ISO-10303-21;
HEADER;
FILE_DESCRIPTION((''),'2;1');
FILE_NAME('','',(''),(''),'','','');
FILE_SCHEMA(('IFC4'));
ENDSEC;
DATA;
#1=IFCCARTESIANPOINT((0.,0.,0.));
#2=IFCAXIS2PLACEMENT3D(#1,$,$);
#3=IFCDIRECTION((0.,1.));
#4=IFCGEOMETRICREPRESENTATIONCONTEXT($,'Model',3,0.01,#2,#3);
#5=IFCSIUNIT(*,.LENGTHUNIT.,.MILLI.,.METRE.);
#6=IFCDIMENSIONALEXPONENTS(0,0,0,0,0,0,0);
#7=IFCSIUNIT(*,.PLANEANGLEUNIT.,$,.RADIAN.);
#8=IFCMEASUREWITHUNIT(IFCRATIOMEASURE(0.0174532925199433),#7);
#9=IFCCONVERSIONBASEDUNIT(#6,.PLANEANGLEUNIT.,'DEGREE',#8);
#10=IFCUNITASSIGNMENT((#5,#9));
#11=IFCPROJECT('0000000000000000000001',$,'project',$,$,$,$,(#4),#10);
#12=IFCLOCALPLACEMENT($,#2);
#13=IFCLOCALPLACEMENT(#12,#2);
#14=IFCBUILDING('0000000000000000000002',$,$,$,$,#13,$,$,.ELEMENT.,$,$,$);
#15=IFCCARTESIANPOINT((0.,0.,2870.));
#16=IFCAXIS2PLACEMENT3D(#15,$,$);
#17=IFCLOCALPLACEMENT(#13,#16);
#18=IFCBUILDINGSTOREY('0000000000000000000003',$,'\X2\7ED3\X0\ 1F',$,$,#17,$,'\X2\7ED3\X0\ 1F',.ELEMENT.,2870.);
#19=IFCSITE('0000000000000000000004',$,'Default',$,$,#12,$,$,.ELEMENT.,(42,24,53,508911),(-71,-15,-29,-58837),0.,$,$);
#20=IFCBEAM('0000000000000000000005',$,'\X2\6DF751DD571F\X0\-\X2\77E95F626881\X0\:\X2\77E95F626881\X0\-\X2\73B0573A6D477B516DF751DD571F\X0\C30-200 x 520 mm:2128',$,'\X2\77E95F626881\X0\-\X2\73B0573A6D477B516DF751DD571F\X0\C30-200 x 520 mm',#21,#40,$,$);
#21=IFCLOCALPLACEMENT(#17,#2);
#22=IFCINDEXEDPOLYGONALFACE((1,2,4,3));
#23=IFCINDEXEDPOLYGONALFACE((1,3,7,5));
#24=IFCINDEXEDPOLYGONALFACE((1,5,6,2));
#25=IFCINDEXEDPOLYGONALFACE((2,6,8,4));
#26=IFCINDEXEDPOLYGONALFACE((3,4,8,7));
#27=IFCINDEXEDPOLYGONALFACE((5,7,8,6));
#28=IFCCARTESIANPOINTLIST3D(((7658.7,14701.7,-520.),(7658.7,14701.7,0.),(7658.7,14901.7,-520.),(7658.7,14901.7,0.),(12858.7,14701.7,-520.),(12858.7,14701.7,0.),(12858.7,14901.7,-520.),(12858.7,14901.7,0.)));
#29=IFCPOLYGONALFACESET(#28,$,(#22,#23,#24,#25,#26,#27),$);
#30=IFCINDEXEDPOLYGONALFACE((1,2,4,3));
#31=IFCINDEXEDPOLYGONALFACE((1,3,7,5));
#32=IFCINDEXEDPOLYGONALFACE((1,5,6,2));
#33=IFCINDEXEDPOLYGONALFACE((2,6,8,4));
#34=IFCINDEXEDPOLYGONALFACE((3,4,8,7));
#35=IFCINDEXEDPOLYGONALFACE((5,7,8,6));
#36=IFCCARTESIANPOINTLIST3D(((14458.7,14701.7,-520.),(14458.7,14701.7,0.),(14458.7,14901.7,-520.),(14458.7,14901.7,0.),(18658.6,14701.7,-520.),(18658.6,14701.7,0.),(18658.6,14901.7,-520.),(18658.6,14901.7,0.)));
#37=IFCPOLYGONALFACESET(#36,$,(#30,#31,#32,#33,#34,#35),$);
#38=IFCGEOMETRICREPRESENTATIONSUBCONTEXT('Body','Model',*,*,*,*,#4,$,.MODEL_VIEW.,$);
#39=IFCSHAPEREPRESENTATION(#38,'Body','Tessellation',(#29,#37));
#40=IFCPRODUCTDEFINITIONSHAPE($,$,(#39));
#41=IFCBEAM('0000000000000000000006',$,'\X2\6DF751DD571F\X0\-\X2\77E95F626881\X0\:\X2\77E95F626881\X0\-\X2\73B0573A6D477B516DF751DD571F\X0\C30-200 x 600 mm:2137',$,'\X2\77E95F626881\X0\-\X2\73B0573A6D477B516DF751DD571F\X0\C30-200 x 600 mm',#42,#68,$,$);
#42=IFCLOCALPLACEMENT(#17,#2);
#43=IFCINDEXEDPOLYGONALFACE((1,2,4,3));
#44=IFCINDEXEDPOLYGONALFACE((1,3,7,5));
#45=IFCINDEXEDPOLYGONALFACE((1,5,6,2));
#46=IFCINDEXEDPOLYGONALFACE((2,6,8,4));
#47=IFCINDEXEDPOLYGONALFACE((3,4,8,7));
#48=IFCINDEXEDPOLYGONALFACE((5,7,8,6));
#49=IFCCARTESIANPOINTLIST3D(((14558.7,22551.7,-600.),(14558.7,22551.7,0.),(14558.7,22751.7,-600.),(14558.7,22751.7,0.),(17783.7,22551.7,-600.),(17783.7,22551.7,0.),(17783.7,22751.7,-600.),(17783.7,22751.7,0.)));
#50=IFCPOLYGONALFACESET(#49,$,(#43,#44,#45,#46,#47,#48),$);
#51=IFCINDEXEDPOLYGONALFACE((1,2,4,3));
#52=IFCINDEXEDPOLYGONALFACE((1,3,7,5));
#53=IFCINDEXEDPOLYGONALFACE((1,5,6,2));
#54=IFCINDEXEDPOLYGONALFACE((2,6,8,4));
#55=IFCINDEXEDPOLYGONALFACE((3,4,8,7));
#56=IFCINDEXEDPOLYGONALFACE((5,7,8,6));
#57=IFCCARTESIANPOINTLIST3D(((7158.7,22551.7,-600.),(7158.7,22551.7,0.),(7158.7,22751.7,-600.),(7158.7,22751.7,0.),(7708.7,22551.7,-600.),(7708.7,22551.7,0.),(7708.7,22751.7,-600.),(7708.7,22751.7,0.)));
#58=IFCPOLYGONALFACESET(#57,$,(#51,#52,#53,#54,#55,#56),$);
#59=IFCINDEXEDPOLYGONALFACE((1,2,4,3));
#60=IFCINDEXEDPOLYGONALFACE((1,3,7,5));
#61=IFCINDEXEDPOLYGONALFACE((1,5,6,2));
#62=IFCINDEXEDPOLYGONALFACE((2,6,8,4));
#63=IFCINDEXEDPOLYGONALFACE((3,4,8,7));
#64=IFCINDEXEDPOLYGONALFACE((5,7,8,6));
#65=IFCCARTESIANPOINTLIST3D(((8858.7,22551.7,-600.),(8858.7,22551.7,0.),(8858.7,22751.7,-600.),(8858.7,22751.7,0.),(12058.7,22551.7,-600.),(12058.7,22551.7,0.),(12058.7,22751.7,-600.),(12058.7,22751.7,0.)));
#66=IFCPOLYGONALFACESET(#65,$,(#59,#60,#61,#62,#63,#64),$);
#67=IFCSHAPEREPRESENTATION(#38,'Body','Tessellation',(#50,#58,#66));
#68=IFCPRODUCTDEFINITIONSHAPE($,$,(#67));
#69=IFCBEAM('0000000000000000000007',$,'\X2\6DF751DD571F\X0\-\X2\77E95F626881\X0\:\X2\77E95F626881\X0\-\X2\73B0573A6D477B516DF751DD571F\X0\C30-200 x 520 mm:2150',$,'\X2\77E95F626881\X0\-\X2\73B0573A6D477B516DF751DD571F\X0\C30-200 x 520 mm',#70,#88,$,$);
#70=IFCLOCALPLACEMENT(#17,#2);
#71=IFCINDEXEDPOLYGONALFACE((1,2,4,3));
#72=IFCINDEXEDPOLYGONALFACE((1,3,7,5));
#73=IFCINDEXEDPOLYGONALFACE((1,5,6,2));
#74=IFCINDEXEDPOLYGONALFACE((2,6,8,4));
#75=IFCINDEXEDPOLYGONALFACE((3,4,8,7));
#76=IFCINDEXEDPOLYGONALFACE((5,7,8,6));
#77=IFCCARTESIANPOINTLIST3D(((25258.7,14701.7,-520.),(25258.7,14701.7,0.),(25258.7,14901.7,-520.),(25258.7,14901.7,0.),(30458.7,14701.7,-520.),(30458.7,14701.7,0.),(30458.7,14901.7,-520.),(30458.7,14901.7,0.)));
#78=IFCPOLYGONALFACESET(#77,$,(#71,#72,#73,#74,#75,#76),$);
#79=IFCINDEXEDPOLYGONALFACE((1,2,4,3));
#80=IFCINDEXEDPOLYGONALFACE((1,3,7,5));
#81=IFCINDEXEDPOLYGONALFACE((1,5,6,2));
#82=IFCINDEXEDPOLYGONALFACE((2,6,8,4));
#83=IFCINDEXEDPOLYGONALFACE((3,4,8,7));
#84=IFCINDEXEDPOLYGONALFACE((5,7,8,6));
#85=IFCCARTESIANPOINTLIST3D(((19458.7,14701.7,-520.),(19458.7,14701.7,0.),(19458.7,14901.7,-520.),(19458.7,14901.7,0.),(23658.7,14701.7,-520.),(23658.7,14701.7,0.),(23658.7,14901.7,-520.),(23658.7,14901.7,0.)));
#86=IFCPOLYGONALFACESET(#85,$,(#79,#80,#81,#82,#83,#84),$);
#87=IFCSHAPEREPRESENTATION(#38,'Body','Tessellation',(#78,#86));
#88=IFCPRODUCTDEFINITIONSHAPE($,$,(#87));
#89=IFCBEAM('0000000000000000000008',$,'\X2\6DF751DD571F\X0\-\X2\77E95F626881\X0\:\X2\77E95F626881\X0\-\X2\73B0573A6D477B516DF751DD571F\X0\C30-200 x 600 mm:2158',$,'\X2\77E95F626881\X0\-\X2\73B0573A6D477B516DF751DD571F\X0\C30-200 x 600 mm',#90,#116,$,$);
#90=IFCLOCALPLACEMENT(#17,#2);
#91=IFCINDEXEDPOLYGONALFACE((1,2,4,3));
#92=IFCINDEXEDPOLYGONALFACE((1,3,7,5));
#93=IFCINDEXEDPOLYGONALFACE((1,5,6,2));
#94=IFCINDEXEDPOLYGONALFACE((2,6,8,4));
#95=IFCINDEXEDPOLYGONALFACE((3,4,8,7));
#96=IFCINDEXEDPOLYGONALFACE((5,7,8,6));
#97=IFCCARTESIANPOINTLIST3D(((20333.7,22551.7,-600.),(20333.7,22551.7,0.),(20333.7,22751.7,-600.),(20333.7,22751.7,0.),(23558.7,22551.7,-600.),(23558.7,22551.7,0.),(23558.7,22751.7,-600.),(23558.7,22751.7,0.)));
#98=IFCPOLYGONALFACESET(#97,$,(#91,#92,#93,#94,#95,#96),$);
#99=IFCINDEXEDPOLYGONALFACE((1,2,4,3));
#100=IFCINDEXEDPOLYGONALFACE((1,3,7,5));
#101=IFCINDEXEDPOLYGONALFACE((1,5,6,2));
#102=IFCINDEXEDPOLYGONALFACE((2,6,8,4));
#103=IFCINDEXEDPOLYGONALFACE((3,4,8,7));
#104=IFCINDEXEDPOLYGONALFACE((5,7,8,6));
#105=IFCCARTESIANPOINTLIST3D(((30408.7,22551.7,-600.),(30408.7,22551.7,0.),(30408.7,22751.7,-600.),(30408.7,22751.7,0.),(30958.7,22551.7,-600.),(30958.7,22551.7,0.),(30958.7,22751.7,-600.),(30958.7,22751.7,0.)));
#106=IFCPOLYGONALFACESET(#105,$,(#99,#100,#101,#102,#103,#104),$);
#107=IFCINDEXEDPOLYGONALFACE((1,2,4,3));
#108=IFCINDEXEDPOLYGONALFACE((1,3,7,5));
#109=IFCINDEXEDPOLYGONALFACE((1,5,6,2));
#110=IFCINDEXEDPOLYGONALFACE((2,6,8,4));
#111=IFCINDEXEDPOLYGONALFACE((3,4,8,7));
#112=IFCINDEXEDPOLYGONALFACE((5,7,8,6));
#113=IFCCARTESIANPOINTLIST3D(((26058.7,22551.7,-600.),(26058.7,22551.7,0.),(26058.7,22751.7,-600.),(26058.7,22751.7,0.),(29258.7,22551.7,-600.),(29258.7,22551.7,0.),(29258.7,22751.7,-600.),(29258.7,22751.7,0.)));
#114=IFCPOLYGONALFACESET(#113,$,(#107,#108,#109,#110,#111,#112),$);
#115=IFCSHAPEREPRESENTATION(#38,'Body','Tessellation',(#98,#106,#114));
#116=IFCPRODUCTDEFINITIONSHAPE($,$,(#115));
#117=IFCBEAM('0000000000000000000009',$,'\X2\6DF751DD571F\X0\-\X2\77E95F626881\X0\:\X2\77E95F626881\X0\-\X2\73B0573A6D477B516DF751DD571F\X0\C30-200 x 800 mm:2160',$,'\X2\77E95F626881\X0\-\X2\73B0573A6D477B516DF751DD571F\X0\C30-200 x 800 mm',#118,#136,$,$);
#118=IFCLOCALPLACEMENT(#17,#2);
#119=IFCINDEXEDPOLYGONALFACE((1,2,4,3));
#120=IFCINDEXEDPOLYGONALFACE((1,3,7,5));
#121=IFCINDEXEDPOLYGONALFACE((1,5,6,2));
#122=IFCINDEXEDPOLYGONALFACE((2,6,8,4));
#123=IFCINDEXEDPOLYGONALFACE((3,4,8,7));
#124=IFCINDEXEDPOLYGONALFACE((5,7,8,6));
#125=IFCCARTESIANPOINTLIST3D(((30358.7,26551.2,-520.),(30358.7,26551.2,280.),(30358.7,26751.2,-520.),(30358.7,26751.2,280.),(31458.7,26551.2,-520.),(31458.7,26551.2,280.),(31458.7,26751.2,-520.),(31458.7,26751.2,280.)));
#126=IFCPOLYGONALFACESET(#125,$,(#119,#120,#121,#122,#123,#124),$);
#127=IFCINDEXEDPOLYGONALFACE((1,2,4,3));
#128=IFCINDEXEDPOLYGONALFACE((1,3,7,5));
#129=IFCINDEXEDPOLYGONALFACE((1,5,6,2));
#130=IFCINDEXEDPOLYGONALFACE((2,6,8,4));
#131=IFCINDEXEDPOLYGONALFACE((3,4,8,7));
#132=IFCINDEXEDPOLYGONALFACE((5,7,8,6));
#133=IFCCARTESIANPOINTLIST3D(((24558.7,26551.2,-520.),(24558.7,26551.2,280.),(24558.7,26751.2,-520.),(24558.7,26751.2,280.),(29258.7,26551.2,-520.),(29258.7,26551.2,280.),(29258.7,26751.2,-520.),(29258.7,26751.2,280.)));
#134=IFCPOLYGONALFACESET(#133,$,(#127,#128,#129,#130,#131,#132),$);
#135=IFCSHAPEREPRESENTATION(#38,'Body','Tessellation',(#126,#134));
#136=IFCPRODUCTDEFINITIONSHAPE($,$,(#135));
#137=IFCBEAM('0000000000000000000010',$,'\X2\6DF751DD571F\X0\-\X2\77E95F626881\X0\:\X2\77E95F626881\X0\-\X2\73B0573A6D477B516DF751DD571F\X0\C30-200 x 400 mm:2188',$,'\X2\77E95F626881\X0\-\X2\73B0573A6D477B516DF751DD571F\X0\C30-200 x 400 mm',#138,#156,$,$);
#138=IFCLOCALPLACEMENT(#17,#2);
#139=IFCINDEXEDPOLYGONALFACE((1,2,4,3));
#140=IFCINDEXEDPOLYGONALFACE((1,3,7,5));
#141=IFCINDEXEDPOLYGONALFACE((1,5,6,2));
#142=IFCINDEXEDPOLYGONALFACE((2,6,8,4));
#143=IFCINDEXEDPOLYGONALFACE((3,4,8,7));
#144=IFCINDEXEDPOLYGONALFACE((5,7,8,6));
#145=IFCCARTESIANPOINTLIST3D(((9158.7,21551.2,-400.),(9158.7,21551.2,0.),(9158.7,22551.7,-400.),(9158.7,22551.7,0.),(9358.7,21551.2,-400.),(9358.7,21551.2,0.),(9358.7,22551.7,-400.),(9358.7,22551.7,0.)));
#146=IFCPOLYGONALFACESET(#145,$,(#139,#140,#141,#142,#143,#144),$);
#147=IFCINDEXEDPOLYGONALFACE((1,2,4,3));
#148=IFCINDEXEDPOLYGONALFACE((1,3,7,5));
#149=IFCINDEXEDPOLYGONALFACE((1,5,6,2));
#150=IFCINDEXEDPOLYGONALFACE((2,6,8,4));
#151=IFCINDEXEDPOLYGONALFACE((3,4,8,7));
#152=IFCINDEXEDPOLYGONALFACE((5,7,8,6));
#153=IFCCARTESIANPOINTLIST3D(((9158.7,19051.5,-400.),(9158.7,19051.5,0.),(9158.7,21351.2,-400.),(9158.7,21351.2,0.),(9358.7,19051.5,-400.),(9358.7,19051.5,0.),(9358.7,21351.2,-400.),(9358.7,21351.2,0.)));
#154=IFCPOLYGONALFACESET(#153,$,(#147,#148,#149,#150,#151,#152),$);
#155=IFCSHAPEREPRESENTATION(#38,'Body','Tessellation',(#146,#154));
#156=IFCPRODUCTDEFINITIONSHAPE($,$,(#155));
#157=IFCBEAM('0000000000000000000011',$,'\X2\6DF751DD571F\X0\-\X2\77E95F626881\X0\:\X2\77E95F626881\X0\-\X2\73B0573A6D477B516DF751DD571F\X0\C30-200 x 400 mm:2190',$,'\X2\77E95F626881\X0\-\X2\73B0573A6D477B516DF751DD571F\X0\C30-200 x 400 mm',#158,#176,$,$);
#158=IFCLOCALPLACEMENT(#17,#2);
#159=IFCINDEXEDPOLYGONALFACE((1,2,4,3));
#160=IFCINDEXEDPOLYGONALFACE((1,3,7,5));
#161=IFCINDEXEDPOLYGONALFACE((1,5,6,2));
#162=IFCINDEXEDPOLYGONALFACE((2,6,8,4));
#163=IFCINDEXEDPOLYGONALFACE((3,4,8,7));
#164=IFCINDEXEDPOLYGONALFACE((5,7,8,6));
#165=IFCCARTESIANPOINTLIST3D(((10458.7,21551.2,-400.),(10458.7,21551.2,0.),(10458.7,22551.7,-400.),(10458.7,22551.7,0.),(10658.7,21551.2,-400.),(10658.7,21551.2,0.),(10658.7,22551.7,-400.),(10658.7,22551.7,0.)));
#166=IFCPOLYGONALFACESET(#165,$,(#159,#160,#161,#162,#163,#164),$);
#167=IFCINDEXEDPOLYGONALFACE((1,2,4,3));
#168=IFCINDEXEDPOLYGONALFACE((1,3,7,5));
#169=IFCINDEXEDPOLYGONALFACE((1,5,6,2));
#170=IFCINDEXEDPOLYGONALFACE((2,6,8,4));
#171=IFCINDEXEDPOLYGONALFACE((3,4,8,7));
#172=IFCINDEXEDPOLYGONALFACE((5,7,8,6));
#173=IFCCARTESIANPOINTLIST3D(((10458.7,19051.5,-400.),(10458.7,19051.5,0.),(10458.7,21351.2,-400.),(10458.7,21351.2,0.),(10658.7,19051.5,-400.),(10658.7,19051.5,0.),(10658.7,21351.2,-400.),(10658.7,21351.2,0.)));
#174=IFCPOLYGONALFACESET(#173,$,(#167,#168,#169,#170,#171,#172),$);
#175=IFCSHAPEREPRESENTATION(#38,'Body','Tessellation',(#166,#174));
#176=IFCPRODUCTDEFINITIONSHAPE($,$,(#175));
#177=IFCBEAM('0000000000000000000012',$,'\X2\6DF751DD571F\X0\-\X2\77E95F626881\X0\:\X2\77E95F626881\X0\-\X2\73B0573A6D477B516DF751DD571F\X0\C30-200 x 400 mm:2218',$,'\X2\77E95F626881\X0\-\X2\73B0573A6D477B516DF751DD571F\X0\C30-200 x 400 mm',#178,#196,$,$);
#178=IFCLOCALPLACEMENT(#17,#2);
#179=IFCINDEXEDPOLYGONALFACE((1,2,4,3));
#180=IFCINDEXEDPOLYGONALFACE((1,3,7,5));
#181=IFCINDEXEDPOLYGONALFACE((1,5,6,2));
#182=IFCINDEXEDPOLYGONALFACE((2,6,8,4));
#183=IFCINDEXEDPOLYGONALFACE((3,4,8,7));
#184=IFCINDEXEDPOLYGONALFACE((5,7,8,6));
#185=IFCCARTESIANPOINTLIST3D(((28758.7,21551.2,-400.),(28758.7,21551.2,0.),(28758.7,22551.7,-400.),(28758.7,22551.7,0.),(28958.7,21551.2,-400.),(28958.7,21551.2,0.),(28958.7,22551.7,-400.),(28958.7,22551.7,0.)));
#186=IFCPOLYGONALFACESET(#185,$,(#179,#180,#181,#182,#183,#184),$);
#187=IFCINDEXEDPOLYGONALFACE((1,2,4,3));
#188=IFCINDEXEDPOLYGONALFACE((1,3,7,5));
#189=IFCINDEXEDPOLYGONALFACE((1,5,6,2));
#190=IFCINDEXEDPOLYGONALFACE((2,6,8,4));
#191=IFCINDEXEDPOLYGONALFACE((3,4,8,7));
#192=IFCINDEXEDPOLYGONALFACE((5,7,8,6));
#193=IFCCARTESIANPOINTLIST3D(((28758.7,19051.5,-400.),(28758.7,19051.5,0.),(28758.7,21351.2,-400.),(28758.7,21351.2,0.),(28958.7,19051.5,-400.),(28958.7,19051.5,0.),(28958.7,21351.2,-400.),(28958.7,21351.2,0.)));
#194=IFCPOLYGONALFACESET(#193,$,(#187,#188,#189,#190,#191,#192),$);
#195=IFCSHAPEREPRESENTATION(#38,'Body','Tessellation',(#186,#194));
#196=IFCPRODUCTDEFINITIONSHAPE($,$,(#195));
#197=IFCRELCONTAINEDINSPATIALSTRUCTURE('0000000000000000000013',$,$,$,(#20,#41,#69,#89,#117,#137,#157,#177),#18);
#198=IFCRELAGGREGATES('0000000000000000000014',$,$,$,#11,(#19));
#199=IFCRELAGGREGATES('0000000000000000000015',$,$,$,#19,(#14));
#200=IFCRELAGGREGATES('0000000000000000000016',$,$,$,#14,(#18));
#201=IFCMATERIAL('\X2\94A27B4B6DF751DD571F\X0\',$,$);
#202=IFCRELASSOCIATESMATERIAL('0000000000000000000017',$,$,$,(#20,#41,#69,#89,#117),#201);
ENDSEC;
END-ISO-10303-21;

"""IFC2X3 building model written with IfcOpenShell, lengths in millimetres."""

from ifc_helpers import new_model, entity, si_unit, converted_unit, direction, frame, frame_2d, origin, origin_2d_with_axis, place, context, subcontext, project, spatial, rectangle, extrude, source, transform, mapped, material, element, save


model = new_model("IFC2X3")

# Units and contexts
model_context = context("Model", 3, precision=0.01, world=origin(), true_north=direction((0.0, 1.0)))
body_context = subcontext(model_context, "Body", "Model", "MODEL_VIEW")
ifc_project = project(units=[si_unit("LENGTHUNIT", "METRE", prefix="MILLI"), converted_unit("PLANEANGLEUNIT", "DEGREE", entity("IfcRatioMeasure", 0.0174532925199433), si_unit("PLANEANGLEUNIT", "RADIAN"), dimensions=[0, 0, 0, 0, 0, 0, 0])], contexts=[model_context])

# Site, building, storey
site_placement = place(None, origin())
site = spatial("IfcSite", under=ifc_project, at=site_placement, Name="Default", CompositionType="ELEMENT", RefLatitude=(42, 24, 53, 508911), RefLongitude=(-71, -15, -29, -58837), RefElevation=0.0)
building_placement = place(site_placement, origin())
building = spatial("IfcBuilding", under=site, at=building_placement, CompositionType="ELEMENT")
storey_placement = place(building_placement, frame((0.0, 0.0, 2870.0)))
storey = spatial("IfcBuildingStorey", under=building, at=storey_placement, Name="结 1F", LongName="结 1F", CompositionType="ELEMENT", Elevation=2870.0)

# Beams
ifc_material = material(Name="钢筋混凝土")
shared_shape_1 = source(origin(), body_context, "Body", "SweptSolid", [
    extrude(rectangle(XDim=5200.0, YDim=200.0, at=frame_2d((0.0, 0.0), x_axis=(1.0, 0.0))), frame((10258.7, 14801.7, 2350.0)), (0.0, 0.0, 1.0), 520.0),
    extrude(rectangle(XDim=4199.9, YDim=200.0, at=frame_2d((0.0, 0.0), x_axis=(1.0, 0.0))), frame((16558.7, 14801.7, 2350.0), z_axis=(0.0, 0.0, 1.0), x_axis=(-1.0, 0.0, 0.0)), (0.0, 0.0, 1.0), 520.0),
])
beam_1_placement = place(storey_placement, frame((0.0, 0.0, -2870.0)))
element("IfcBeam", 1, at=beam_1_placement, inside=storey, material=ifc_material, Name="混凝土-矩形梁:矩形梁-现场浇筑混凝土C30-200 x 520 mm:2128", ObjectType="矩形梁-现场浇筑混凝土C30-200 x 520 mm", context=body_context, shape_type="MappedRepresentation", body=[
    mapped(shared_shape_1, transform((0.0, 0.0, 0.0), scale=1.0)),
])
shared_shape_2 = source(origin(), body_context, "Body", "SweptSolid", [
    extrude(rectangle(XDim=3225.0, YDim=200.0, at=frame_2d((0.0, 0.0), x_axis=(1.0, 0.0))), frame((16171.2, 22651.7, 2270.0)), (0.0, 0.0, 1.0), 600.0),
    extrude(rectangle(XDim=550.0, YDim=200.0, at=frame_2d((0.0, 0.0), x_axis=(1.0, 0.0))), frame((7433.7, 22651.7, 2270.0), z_axis=(0.0, 0.0, 1.0), x_axis=(-1.0, 0.0, 0.0)), (0.0, 0.0, 1.0), 600.0),
    extrude(rectangle(XDim=3200.0, YDim=200.0, at=frame_2d((0.0, 0.0), x_axis=(1.0, 0.0))), frame((10458.7, 22651.7, 2270.0)), (0.0, 0.0, 1.0), 600.0),
])
beam_2_placement = place(storey_placement, frame((0.0, 0.0, -2870.0)))
element("IfcBeam", 2, at=beam_2_placement, inside=storey, material=ifc_material, Name="混凝土-矩形梁:矩形梁-现场浇筑混凝土C30-200 x 600 mm:2137", ObjectType="矩形梁-现场浇筑混凝土C30-200 x 600 mm", context=body_context, shape_type="MappedRepresentation", body=[
    mapped(shared_shape_2, transform((0.0, 0.0, 0.0), scale=1.0)),
])
shared_shape_3 = source(origin(), body_context, "Body", "SweptSolid", [
    extrude(rectangle(XDim=5200.0, YDim=200.0, at=frame_2d((0.0, 0.0), x_axis=(1.0, 0.0))), frame((27858.7, 14801.7, 2350.0)), (0.0, 0.0, 1.0), 520.0),
    extrude(rectangle(XDim=4200.0, YDim=200.0, at=frame_2d((0.0, 0.0), x_axis=(1.0, 0.0))), frame((21558.7, 14801.7, 2350.0)), (0.0, 0.0, 1.0), 520.0),
])
beam_3_placement = place(storey_placement, frame((0.0, 0.0, -2870.0)))
element("IfcBeam", 3, at=beam_3_placement, inside=storey, material=ifc_material, Name="混凝土-矩形梁:矩形梁-现场浇筑混凝土C30-200 x 520 mm:2150", ObjectType="矩形梁-现场浇筑混凝土C30-200 x 520 mm", context=body_context, shape_type="MappedRepresentation", body=[
    mapped(shared_shape_3, transform((0.0, 0.0, 0.0), scale=1.0)),
])
shared_shape_4 = source(origin(), body_context, "Body", "SweptSolid", [
    extrude(rectangle(XDim=3225.0, YDim=200.0, at=frame_2d((0.0, 0.0), x_axis=(1.0, 0.0))), frame((21946.2, 22651.7, 2270.0)), (0.0, 0.0, 1.0), 600.0),
    extrude(rectangle(XDim=550.0, YDim=200.0, at=frame_2d((0.0, 0.0), x_axis=(1.0, 0.0))), frame((30683.7, 22651.7, 2270.0)), (0.0, 0.0, 1.0), 600.0),
    extrude(rectangle(XDim=3200.0, YDim=200.0, at=frame_2d((0.0, 0.0), x_axis=(1.0, 0.0))), frame((27658.7, 22651.7, 2270.0), z_axis=(0.0, 0.0, 1.0), x_axis=(-1.0, 0.0, 0.0)), (0.0, 0.0, 1.0), 600.0),
])
beam_4_placement = place(storey_placement, frame((0.0, 0.0, -2870.0)))
element("IfcBeam", 4, at=beam_4_placement, inside=storey, material=ifc_material, Name="混凝土-矩形梁:矩形梁-现场浇筑混凝土C30-200 x 600 mm:2158", ObjectType="矩形梁-现场浇筑混凝土C30-200 x 600 mm", context=body_context, shape_type="MappedRepresentation", body=[
    mapped(shared_shape_4, transform((0.0, 0.0, 0.0), scale=1.0)),
])
shared_shape_5 = source(origin(), body_context, "Body", "SweptSolid", [
    extrude(rectangle(XDim=1100.0, YDim=200.0, at=frame_2d((116.7, 0.0), x_axis=(1.0, 0.0))), frame((31025.4, 26651.2, 2350.0), z_axis=(0.0, 0.0, 1.0), x_axis=(-1.0, 0.0, 0.0)), (0.0, 0.0, 1.0), 800.0),
    extrude(rectangle(XDim=200.0, YDim=4700.0, at=origin_2d_with_axis()), frame((26908.7, 26651.2, 2350.0), z_axis=(0.0, 0.0, 1.0), x_axis=(0.0, 1.0, 0.0)), (0.0, 0.0, 1.0), 800.0),
])
beam_5_placement = place(storey_placement, frame((0.0, 0.0, -2870.0)))
element("IfcBeam", 5, at=beam_5_placement, inside=storey, material=ifc_material, Name="混凝土-矩形梁:矩形梁-现场浇筑混凝土C30-200 x 800 mm:2160", ObjectType="矩形梁-现场浇筑混凝土C30-200 x 800 mm", context=body_context, shape_type="MappedRepresentation", body=[
    mapped(shared_shape_5, transform((0.0, 0.0, 0.0), scale=1.0)),
])
shared_shape_6 = source(origin(), body_context, "Body", "SweptSolid", [
    extrude(rectangle(XDim=1000.5, YDim=200.0, at=frame_2d((0.0, 0.0), x_axis=(1.0, 0.0))), frame((9258.7, 22051.5, 2470.0), z_axis=(0.0, 0.0, 1.0), x_axis=(0.0, -1.0, 0.0)), (0.0, 0.0, 1.0), 400.0),
    extrude(rectangle(XDim=2299.8, YDim=200.0, at=frame_2d((0.0, 0.0), x_axis=(1.0, 0.0))), frame((9258.7, 20201.3, 2470.0), z_axis=(0.0, 0.0, 1.0), x_axis=(0.0, 1.0, 0.0)), (0.0, 0.0, 1.0), 400.0),
])
beam_6_placement = place(storey_placement, frame((0.0, 0.0, -2870.0)))
element("IfcBeam", 6, at=beam_6_placement, inside=storey, Name="混凝土-矩形梁:矩形梁-现场浇筑混凝土C30-200 x 400 mm:2188", ObjectType="矩形梁-现场浇筑混凝土C30-200 x 400 mm", context=body_context, shape_type="MappedRepresentation", body=[
    mapped(shared_shape_6, transform((0.0, 0.0, 0.0), scale=1.0)),
])
shared_shape_7 = source(origin(), body_context, "Body", "SweptSolid", [
    extrude(rectangle(XDim=1000.5, YDim=200.0, at=frame_2d((0.0, 0.0), x_axis=(1.0, 0.0))), frame((10558.7, 22051.5, 2470.0), z_axis=(0.0, 0.0, 1.0), x_axis=(0.0, -1.0, 0.0)), (0.0, 0.0, 1.0), 400.0),
    extrude(rectangle(XDim=2299.8, YDim=200.0, at=frame_2d((0.0, 0.0), x_axis=(1.0, 0.0))), frame((10558.7, 20201.3, 2470.0), z_axis=(0.0, 0.0, 1.0), x_axis=(0.0, 1.0, 0.0)), (0.0, 0.0, 1.0), 400.0),
])
beam_7_placement = place(storey_placement, frame((0.0, 0.0, -2870.0)))
element("IfcBeam", 7, at=beam_7_placement, inside=storey, Name="混凝土-矩形梁:矩形梁-现场浇筑混凝土C30-200 x 400 mm:2190", ObjectType="矩形梁-现场浇筑混凝土C30-200 x 400 mm", context=body_context, shape_type="MappedRepresentation", body=[
    mapped(shared_shape_7, transform((0.0, 0.0, 0.0), scale=1.0)),
])
shared_shape_8 = source(origin(), body_context, "Body", "SweptSolid", [
    extrude(rectangle(XDim=1000.5, YDim=200.0, at=frame_2d((0.0, 0.0), x_axis=(1.0, 0.0))), frame((28858.7, 22051.5, 2470.0), z_axis=(0.0, 0.0, 1.0), x_axis=(0.0, -1.0, 0.0)), (0.0, 0.0, 1.0), 400.0),
    extrude(rectangle(XDim=2299.8, YDim=200.0, at=frame_2d((0.0, 0.0), x_axis=(1.0, 0.0))), frame((28858.7, 20201.3, 2470.0), z_axis=(0.0, 0.0, 1.0), x_axis=(0.0, 1.0, 0.0)), (0.0, 0.0, 1.0), 400.0),
])
beam_8_placement = place(storey_placement, frame((0.0, 0.0, -2870.0)))
element("IfcBeam", 8, at=beam_8_placement, inside=storey, Name="混凝土-矩形梁:矩形梁-现场浇筑混凝土C30-200 x 400 mm:2218", ObjectType="矩形梁-现场浇筑混凝土C30-200 x 400 mm", context=body_context, shape_type="MappedRepresentation", body=[
    mapped(shared_shape_8, transform((0.0, 0.0, 0.0), scale=1.0)),
])

save(model, "model.ifc")
